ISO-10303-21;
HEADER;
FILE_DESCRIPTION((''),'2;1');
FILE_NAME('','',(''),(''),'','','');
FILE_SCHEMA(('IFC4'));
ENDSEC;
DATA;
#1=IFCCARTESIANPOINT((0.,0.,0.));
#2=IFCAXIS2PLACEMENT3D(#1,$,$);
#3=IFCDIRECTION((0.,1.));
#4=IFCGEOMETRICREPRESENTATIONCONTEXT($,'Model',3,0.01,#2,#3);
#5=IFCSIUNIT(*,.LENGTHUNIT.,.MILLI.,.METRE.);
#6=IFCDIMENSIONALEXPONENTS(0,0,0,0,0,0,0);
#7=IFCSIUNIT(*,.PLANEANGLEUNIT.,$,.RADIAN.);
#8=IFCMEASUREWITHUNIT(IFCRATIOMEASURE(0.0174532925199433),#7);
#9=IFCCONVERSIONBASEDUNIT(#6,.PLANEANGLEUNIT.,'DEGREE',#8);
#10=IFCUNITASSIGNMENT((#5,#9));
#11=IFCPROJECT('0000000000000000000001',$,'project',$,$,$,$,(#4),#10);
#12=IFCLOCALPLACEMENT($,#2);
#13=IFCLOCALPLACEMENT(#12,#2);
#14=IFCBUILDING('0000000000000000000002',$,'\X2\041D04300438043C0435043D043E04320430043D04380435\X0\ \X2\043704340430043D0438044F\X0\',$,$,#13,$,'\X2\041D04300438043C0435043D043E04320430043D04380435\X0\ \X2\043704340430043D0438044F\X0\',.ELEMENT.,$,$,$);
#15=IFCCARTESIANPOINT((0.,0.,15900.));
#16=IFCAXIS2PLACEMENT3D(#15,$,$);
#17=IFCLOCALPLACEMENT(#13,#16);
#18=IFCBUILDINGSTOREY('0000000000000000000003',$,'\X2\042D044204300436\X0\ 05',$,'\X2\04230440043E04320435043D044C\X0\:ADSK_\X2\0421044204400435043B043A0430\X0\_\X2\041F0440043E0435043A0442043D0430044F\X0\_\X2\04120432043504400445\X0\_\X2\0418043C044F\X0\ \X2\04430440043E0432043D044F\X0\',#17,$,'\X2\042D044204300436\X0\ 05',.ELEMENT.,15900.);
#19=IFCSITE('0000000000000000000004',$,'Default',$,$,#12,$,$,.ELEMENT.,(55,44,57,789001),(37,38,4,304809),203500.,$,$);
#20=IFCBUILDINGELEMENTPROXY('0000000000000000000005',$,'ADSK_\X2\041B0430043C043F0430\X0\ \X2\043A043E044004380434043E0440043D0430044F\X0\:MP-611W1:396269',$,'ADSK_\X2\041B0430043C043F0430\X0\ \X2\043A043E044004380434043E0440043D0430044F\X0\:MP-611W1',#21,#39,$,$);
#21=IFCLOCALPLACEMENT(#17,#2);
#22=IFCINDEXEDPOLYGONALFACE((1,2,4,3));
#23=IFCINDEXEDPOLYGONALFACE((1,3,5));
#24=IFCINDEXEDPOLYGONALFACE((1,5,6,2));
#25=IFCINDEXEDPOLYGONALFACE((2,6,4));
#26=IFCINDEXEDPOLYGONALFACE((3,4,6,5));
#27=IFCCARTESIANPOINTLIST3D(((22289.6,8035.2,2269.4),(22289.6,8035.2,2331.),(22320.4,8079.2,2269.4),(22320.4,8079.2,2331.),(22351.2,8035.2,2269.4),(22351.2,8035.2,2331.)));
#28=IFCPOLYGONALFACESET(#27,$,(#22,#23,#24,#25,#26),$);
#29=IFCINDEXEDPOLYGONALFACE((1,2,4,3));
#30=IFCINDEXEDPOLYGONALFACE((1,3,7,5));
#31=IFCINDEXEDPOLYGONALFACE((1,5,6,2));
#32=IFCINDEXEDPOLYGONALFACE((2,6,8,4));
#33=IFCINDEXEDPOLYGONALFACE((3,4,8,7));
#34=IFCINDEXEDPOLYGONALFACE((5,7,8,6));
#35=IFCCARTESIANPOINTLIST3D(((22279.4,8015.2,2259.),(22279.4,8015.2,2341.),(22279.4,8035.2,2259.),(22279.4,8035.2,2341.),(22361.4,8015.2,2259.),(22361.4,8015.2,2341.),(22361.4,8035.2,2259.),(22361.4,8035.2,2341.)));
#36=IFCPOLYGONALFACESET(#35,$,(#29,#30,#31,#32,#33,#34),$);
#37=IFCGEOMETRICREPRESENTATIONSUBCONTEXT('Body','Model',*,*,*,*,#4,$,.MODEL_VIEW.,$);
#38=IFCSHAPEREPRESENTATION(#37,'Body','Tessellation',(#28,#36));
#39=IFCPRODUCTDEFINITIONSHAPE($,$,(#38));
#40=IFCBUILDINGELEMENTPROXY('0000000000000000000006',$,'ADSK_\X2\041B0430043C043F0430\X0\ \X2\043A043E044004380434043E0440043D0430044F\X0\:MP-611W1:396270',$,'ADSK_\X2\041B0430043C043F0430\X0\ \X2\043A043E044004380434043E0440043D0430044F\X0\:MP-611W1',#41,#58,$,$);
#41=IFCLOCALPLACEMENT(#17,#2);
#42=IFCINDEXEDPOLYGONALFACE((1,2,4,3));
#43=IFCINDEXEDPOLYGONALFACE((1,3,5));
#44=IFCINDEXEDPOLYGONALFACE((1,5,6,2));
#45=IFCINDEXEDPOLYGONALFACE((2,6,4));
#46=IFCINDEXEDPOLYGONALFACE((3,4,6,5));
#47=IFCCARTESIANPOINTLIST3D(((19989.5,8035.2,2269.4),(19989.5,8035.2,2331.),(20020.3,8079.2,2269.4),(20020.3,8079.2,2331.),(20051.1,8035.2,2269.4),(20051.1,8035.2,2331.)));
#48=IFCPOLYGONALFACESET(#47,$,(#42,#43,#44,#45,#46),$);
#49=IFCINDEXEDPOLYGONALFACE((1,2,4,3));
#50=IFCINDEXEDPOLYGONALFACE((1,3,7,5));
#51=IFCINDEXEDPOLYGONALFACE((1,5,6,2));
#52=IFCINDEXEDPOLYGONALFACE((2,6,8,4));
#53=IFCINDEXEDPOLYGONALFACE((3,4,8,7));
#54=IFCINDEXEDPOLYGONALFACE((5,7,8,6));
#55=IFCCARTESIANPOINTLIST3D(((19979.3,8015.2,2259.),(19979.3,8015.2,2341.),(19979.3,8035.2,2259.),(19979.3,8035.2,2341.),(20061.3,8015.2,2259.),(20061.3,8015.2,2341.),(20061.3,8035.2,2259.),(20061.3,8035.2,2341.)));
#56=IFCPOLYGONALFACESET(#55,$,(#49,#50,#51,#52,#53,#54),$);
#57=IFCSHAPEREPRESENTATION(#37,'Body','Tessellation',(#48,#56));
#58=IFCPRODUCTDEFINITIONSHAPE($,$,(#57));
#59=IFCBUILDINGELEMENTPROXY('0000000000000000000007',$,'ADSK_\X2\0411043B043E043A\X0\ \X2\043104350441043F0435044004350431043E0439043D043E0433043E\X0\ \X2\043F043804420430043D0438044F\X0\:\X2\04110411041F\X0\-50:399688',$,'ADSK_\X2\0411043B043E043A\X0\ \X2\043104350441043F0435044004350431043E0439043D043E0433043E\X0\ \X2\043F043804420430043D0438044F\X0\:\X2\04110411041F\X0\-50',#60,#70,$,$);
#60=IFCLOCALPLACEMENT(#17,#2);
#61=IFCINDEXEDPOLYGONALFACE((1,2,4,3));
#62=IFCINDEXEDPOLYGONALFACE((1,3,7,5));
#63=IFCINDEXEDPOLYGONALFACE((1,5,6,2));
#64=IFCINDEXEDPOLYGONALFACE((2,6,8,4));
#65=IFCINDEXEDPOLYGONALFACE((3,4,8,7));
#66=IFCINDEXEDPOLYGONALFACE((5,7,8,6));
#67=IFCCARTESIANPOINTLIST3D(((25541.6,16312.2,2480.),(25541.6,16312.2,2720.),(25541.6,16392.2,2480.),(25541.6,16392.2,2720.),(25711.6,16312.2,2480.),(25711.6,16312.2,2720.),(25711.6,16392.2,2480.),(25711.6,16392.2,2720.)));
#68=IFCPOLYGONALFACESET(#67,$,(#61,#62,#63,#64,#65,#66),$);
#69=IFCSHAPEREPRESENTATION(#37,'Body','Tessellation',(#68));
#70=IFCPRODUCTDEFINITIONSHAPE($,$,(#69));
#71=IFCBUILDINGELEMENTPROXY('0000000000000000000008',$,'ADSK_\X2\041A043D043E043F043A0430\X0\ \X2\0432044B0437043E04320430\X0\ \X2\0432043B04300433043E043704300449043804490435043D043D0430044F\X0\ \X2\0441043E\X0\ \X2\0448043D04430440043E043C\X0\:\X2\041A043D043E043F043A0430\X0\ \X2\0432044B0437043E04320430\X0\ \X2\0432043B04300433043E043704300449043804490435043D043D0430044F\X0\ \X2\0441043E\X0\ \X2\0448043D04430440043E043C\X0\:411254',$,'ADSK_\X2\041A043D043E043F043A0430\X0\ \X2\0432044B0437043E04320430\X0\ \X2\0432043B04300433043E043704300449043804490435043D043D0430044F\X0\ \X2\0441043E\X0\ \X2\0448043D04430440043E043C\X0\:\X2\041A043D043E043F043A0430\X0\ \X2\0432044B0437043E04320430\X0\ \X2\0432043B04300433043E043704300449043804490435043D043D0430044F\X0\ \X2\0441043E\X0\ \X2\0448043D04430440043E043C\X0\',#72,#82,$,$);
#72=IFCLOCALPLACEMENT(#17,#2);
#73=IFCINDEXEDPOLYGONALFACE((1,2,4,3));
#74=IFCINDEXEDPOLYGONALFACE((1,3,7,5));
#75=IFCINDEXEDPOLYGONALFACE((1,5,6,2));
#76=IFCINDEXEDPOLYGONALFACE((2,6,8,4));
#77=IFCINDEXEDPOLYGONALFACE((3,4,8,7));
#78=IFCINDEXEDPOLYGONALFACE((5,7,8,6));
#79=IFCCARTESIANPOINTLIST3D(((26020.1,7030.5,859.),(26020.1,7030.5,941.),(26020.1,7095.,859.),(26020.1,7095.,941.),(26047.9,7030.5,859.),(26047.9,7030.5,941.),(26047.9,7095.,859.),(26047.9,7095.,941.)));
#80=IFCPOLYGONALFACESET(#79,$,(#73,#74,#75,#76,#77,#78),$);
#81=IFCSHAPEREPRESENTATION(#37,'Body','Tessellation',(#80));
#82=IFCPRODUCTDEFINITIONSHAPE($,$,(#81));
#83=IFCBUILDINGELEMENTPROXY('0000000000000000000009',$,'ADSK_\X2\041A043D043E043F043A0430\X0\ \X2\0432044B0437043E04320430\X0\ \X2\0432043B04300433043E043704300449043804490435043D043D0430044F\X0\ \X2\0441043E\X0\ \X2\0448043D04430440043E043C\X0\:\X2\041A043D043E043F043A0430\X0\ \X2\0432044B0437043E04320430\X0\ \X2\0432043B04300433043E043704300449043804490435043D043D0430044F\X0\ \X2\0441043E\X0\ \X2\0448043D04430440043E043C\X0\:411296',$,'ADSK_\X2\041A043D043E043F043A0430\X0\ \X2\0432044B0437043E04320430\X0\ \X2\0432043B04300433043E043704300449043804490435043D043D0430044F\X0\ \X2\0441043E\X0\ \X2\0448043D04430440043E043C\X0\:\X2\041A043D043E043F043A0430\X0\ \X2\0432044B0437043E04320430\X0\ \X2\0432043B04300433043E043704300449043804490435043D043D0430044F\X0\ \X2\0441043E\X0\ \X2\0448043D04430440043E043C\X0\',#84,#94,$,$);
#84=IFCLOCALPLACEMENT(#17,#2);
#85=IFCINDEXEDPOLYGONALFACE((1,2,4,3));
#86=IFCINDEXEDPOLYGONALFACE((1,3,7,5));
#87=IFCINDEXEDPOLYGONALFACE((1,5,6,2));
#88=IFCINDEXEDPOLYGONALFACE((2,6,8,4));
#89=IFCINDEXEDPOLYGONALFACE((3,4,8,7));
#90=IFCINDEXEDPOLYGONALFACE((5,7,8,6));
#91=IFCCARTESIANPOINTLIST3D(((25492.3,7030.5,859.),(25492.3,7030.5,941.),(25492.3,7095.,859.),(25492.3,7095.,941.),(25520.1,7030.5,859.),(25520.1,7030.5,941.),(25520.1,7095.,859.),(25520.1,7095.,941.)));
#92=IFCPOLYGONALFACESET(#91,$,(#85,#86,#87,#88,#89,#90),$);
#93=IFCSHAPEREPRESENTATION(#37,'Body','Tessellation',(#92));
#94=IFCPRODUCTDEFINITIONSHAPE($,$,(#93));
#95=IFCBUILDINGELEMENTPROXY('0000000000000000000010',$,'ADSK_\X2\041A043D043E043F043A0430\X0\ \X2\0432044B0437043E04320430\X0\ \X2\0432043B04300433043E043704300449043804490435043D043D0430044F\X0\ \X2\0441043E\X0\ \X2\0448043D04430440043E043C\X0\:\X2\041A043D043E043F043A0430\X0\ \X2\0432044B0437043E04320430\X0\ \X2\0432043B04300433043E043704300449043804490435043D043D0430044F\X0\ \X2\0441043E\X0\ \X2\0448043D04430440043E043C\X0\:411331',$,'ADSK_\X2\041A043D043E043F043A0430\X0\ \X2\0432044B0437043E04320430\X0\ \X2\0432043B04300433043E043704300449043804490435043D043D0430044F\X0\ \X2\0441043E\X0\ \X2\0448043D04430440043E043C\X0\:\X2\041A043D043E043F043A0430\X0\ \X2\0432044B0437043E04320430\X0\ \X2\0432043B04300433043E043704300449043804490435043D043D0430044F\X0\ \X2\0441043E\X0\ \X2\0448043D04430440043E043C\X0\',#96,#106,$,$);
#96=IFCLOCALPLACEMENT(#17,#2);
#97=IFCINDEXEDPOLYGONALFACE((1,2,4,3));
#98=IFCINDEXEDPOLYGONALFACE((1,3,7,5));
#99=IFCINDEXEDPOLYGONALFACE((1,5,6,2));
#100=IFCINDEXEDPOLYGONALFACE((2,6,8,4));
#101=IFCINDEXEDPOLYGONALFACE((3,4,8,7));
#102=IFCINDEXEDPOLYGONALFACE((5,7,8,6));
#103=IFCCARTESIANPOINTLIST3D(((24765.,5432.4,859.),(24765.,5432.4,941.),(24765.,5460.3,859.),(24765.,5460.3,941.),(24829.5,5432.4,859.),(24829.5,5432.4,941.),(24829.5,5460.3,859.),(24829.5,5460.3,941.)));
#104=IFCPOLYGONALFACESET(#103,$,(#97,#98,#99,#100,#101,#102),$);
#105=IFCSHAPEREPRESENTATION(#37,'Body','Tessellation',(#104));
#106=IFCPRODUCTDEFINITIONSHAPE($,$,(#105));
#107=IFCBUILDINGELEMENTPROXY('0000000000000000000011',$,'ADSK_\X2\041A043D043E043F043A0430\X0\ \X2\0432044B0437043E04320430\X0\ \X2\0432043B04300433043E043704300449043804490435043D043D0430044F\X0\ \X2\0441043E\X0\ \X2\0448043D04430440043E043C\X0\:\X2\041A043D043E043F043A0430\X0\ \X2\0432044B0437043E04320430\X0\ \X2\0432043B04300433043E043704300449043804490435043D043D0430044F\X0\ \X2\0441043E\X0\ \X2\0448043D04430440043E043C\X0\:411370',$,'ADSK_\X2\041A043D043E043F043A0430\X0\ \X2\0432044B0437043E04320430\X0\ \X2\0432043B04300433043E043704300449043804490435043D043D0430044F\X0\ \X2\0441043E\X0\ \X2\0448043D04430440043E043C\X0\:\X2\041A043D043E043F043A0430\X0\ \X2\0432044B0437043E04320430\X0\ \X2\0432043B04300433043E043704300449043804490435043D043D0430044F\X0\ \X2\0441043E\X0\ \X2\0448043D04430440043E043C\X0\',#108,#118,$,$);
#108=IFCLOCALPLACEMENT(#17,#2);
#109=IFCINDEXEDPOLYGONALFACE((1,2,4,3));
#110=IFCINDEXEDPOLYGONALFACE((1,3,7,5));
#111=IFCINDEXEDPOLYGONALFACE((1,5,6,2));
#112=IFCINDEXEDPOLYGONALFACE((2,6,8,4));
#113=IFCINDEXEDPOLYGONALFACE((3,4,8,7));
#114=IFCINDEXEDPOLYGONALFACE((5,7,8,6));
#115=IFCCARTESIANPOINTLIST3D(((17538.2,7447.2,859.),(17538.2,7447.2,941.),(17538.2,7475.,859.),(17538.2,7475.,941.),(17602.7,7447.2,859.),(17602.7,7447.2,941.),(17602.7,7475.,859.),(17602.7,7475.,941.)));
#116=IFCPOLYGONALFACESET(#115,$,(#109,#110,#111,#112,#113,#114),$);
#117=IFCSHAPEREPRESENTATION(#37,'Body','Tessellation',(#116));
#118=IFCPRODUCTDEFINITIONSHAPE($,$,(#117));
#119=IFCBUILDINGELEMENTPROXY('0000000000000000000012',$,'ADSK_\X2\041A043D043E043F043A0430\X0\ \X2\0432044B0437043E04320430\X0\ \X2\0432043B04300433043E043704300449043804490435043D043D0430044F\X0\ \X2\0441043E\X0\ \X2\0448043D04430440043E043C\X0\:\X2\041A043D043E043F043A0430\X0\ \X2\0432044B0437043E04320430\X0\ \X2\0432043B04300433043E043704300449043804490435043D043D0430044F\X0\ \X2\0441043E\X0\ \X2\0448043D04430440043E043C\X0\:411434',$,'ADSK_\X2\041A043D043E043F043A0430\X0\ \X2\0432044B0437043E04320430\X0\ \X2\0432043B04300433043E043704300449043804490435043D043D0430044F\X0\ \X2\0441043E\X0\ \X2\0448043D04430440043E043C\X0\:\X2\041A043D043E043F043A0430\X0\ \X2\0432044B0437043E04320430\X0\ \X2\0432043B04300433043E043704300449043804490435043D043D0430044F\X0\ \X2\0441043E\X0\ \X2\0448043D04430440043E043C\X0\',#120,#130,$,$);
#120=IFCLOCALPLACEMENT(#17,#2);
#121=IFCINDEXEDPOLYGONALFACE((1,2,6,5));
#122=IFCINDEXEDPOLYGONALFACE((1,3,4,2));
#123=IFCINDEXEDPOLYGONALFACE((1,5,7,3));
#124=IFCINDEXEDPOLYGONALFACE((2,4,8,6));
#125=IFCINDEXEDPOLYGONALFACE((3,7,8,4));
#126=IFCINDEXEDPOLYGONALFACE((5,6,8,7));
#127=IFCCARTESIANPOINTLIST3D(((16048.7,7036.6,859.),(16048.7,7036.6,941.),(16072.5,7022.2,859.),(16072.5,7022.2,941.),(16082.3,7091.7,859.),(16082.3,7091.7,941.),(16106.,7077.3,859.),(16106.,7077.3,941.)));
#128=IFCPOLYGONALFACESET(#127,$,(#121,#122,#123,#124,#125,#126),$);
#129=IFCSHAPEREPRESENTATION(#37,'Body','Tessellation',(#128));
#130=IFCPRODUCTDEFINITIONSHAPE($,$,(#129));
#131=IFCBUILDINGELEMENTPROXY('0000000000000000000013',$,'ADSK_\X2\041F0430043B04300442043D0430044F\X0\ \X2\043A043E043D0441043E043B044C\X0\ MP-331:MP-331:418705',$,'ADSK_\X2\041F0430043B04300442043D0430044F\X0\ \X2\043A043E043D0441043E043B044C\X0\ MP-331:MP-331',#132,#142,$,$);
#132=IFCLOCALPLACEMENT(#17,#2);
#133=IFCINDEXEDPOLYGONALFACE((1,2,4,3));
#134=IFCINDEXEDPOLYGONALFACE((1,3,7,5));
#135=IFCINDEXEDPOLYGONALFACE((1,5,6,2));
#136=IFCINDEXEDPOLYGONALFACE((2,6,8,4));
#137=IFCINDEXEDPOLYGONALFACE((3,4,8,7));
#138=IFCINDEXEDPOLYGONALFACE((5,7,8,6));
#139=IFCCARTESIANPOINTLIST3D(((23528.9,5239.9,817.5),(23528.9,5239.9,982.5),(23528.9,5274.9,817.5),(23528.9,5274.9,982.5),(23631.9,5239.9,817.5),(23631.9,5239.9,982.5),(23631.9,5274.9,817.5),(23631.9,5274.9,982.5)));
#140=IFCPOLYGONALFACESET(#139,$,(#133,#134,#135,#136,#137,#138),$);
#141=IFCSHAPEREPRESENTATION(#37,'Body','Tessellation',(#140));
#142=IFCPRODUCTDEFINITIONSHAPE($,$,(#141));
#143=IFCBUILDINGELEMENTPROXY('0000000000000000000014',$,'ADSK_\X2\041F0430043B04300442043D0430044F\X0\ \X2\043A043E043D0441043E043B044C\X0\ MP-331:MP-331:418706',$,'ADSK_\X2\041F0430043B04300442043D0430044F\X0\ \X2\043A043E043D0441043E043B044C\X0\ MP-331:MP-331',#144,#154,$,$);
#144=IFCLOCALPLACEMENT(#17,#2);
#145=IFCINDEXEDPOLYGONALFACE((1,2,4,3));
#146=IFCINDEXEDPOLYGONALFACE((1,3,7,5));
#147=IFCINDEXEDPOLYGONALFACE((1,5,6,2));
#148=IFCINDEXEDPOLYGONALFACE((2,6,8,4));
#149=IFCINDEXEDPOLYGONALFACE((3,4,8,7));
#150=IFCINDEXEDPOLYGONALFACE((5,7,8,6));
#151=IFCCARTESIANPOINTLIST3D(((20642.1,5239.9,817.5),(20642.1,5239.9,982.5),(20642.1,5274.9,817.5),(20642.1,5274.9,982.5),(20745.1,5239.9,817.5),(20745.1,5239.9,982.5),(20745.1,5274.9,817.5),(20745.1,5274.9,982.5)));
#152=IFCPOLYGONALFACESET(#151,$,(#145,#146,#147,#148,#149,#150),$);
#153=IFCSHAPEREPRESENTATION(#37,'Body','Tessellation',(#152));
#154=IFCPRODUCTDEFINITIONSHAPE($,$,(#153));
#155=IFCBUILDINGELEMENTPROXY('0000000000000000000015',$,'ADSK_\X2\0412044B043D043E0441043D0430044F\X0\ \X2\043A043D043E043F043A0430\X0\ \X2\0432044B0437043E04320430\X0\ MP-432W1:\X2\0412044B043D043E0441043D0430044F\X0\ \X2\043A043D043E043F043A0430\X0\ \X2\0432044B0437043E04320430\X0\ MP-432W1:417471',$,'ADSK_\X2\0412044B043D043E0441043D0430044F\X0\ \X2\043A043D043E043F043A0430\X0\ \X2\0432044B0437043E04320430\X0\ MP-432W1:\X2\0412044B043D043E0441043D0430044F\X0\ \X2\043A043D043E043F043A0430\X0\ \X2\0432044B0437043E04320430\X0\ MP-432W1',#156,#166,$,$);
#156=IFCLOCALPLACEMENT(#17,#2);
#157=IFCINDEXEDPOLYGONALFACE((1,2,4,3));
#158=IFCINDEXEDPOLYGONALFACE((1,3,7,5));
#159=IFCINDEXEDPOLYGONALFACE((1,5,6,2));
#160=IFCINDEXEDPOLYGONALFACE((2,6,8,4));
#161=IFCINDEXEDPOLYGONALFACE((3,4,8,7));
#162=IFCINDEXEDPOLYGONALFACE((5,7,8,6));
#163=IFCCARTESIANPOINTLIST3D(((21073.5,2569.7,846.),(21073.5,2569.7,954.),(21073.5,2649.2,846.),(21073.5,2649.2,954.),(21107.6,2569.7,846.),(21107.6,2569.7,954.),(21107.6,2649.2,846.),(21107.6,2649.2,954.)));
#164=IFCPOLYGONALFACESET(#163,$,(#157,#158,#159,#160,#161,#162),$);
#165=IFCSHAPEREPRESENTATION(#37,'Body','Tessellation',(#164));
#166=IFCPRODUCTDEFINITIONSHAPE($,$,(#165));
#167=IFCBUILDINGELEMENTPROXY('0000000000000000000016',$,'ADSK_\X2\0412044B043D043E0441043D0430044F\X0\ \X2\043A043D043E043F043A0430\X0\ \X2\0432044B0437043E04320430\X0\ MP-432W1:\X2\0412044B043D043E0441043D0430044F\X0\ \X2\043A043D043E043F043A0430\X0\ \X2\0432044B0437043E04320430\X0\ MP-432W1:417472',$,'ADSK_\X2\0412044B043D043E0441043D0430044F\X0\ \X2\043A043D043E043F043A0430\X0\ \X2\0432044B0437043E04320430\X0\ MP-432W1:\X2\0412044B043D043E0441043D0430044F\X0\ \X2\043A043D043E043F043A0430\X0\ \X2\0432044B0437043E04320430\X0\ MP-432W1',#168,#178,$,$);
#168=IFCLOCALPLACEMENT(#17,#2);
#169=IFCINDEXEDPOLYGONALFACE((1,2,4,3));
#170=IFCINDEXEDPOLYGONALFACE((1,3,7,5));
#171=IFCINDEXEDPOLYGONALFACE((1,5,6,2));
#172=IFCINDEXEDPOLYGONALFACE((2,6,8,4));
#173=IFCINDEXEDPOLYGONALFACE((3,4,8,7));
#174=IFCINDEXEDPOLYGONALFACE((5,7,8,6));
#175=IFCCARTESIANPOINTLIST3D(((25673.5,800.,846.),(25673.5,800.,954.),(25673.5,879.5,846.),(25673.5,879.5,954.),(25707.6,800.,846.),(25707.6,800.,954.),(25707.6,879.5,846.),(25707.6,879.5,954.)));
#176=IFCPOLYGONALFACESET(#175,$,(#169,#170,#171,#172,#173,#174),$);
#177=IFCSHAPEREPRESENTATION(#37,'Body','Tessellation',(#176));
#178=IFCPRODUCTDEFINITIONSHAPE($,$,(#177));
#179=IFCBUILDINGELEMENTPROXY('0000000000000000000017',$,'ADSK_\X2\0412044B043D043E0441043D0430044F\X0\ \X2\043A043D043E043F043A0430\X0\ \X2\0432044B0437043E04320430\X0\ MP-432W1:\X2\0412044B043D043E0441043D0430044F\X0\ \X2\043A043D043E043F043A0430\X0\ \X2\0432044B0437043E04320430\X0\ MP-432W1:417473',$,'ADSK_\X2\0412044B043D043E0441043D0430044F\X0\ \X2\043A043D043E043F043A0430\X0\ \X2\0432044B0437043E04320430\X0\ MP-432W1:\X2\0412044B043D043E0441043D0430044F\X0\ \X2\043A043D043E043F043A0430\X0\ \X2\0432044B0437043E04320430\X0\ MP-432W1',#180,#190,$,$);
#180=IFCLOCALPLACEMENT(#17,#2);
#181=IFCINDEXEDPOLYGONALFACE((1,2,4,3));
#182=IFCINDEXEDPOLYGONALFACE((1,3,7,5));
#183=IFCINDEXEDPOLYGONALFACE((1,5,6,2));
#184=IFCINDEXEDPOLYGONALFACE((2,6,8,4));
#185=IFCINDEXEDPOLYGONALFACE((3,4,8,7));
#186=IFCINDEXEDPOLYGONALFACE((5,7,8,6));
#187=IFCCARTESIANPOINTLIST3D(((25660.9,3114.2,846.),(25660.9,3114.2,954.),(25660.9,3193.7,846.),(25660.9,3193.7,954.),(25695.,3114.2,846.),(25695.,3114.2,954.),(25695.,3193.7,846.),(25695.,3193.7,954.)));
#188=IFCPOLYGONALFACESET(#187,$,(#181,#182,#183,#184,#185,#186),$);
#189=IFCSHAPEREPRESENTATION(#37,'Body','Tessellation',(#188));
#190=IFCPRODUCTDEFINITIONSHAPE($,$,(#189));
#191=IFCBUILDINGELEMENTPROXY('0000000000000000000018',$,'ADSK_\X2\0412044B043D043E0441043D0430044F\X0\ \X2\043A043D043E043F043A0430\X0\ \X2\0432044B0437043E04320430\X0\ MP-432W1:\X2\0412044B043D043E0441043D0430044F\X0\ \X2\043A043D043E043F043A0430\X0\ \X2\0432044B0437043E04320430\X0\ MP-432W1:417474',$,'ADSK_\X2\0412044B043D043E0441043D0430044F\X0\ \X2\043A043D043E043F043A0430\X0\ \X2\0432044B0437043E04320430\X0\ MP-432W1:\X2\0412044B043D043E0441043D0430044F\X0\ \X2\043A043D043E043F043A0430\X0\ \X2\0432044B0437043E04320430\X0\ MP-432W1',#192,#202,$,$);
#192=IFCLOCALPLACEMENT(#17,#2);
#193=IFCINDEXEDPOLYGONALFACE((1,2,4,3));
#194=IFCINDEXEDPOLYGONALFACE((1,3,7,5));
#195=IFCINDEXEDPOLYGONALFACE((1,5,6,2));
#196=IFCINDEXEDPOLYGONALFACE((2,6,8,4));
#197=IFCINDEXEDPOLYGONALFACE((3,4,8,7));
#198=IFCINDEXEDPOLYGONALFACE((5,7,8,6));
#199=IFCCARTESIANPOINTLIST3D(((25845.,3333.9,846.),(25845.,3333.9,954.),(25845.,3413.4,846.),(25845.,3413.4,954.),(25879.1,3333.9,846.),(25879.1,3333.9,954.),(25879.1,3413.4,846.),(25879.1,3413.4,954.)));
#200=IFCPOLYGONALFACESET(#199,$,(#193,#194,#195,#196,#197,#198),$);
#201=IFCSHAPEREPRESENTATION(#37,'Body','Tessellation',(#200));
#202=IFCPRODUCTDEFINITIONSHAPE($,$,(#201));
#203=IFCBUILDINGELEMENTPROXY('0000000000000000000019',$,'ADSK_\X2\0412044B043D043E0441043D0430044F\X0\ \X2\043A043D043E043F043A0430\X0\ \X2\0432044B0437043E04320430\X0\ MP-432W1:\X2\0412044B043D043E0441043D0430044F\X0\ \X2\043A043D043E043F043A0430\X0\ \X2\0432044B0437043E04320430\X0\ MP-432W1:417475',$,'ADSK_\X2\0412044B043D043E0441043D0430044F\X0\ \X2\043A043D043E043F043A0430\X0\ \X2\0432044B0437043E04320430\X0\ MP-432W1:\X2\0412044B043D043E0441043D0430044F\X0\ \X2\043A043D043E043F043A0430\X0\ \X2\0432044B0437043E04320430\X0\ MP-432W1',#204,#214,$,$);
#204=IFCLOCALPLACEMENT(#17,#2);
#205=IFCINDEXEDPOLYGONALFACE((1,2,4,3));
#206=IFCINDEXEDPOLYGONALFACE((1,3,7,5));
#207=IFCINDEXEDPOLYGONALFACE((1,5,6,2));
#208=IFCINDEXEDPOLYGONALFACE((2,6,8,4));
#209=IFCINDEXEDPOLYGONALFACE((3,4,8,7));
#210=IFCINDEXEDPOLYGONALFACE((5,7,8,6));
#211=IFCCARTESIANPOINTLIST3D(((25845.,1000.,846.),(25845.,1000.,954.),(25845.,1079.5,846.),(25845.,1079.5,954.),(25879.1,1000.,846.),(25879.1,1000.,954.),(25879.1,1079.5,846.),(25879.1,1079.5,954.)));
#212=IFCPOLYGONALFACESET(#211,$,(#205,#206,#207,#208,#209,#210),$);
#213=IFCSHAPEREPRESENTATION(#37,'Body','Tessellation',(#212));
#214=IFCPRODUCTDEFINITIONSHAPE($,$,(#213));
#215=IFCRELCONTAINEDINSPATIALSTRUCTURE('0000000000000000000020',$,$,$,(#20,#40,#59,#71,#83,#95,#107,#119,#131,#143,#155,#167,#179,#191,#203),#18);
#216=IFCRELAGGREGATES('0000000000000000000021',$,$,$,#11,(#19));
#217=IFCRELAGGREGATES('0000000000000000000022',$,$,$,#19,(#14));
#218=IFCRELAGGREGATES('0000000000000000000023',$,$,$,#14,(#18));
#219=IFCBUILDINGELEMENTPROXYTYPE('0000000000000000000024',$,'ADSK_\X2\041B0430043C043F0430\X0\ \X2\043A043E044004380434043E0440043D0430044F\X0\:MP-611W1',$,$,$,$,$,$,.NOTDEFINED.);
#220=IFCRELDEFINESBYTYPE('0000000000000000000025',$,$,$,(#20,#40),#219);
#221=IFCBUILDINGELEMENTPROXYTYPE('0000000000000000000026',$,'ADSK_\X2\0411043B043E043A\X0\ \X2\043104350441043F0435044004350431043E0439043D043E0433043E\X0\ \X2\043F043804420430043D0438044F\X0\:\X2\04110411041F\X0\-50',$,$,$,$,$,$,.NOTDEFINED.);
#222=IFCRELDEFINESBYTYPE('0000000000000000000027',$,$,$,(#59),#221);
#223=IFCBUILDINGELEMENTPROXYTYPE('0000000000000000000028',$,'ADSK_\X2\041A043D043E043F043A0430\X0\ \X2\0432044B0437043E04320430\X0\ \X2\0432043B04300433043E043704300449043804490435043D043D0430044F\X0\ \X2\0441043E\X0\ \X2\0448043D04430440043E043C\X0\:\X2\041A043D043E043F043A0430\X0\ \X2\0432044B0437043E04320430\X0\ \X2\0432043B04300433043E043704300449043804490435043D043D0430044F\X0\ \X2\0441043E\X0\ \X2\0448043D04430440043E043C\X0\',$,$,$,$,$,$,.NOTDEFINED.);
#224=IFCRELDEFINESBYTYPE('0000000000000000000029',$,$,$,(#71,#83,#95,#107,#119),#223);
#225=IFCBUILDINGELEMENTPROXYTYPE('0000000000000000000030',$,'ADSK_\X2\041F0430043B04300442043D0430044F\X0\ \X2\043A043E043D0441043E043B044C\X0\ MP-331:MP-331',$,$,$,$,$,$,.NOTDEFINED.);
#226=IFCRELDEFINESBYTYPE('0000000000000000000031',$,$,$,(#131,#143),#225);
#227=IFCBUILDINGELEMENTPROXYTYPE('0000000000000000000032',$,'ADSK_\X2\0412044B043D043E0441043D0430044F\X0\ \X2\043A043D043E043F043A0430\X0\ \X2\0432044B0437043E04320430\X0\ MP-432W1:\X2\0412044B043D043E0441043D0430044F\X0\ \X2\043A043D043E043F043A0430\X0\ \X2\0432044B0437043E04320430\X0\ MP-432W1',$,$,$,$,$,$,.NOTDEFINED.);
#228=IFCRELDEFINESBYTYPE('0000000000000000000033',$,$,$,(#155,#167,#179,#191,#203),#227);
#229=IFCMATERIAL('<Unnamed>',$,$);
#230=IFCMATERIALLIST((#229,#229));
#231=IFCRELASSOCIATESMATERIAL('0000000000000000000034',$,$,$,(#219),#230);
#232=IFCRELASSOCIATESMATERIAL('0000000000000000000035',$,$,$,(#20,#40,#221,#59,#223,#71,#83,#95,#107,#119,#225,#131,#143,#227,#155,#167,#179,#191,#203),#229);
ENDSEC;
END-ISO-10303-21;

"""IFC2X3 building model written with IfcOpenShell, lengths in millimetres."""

from ifc_helpers import new_model, entity, si_unit, converted_unit, direction, frame, origin, origin_2d_with_axis, place, context, subcontext, project, spatial, polyline, rectangle, outline, extrude, source, transform, mapped, material, material_list, type_object, type_shapes, element, save


model = new_model("IFC2X3")

# Units and contexts
model_context = context("Model", 3, precision=0.01, world=origin(), true_north=direction((0.0, 1.0)))
body_context = subcontext(model_context, "Body", "Model", "MODEL_VIEW")
ifc_project = project(units=[si_unit("LENGTHUNIT", "METRE", prefix="MILLI"), converted_unit("PLANEANGLEUNIT", "DEGREE", entity("IfcRatioMeasure", 0.0174532925199433), si_unit("PLANEANGLEUNIT", "RADIAN"), dimensions=[0, 0, 0, 0, 0, 0, 0])], contexts=[model_context])

# Site, building, storey
site_placement = place(None, origin())
site = spatial("IfcSite", under=ifc_project, at=site_placement, Name="Default", CompositionType="ELEMENT", RefLatitude=(55, 44, 57, 789001), RefLongitude=(37, 38, 4, 304809), RefElevation=203500.0)
building_placement = place(site_placement, origin())
building = spatial("IfcBuilding", under=site, at=building_placement, Name="Наименование здания", LongName="Наименование здания", CompositionType="ELEMENT")
storey_placement = place(building_placement, frame((0.0, 0.0, 15900.0)))
storey = spatial("IfcBuildingStorey", under=building, at=storey_placement, Name="Этаж 05", ObjectType="Уровень:ADSK_Стрелка_Проектная_Вверх_Имя уровня", LongName="Этаж 05", CompositionType="ELEMENT", Elevation=15900.0)

# Building element proxies
ifc_material_1 = material(Name="<Unnamed>")
ifc_material_list_1 = material_list([ifc_material_1, ifc_material_1])
building_element_proxy_type_1 = type_object("IfcBuildingElementProxyType", Name="ADSK_Лампа коридорная:MP-611W1", PredefinedType="NOTDEFINED", material=ifc_material_list_1)
shared_shape_1 = source(origin(), body_context, "Body", "SweptSolid", [
    extrude(outline(polyline([(-30.8, -14.7), (30.8, -14.7), (0.0, 29.3), (-30.8, -14.7)])), frame((0.0, -2.7, -30.6), z_axis=(0.0, 0.0, 1.0), x_axis=(-1.0, 0.0, 0.0)), (0.0, 0.0, 1.0), 61.6),
    extrude(rectangle(XDim=82.0, YDim=20.0, at=origin_2d_with_axis()), frame((0.0, 22.0, -41.0), z_axis=(0.0, 0.0, 1.0), x_axis=(-1.0, 0.0, 0.0)), (0.0, 0.0, 1.0), 82.0),
])
type_shapes(building_element_proxy_type_1, [shared_shape_1])
for number, where, z_axis, x_axis, name in (
    (1, (22320.4, 8047.1, 2300.0), (0.0, 0.0, 1.0), (-1.0, 0.0, 0.0), "ADSK_Лампа коридорная:MP-611W1:396269"),
    (2, (20020.3, 8047.1, 2300.0), (0.0, 0.0, 1.0), (-1.0, 0.0, 0.0), "ADSK_Лампа коридорная:MP-611W1:396270"),
):
    element("IfcBuildingElementProxy", number, at=place(storey_placement, frame(where, z_axis=z_axis, x_axis=x_axis)), inside=storey, type_object=building_element_proxy_type_1, material=ifc_material_1, Name=name, ObjectType="ADSK_Лампа коридорная:MP-611W1", context=body_context, shape_type="MappedRepresentation", body=[
        mapped(shared_shape_1, transform((0.0, 0.0, 0.0), scale=1.0)),
    ])
building_element_proxy_type_2 = type_object("IfcBuildingElementProxyType", Name="ADSK_Блок бесперебойного питания:ББП-50", PredefinedType="NOTDEFINED", material=ifc_material_1)
shared_shape_2 = source(origin(), body_context, "Body", "SweptSolid", [
    extrude(rectangle(XDim=170.0, YDim=80.0, at=origin_2d_with_axis()), frame((0.0, -8.0, -120.0), z_axis=(0.0, 0.0, 1.0), x_axis=(-1.0, 0.0, 0.0)), (0.0, 0.0, 1.0), 240.0),
])
type_shapes(building_element_proxy_type_2, [shared_shape_2])
proxy_1_placement = place(storey_placement, frame((25626.6, 16360.2, 2600.0)))
element("IfcBuildingElementProxy", 3, at=proxy_1_placement, inside=storey, type_object=building_element_proxy_type_2, material=ifc_material_1, Name="ADSK_Блок бесперебойного питания:ББП-50:399688", ObjectType="ADSK_Блок бесперебойного питания:ББП-50", context=body_context, shape_type="MappedRepresentation", body=[
    mapped(shared_shape_2, transform((0.0, 0.0, 0.0), scale=1.0)),
])
building_element_proxy_type_3 = type_object("IfcBuildingElementProxyType", Name="ADSK_Кнопка вызова влагозащищенная со шнуром:Кнопка вызова влагозащищенная со шнуром", PredefinedType="NOTDEFINED", material=ifc_material_1)
shared_shape_3 = source(origin(), body_context, "Body", "SweptSolid", [
    extrude(rectangle(XDim=64.5, YDim=27.8, at=origin_2d_with_axis()), frame((32.2, 13.9, 0.0), z_axis=(0.0, 0.0, 1.0), x_axis=(-1.0, 0.0, 0.0)), (0.0, 0.0, 1.0), 82.0),
])
type_shapes(building_element_proxy_type_3, [shared_shape_3])
for number, where, z_axis, x_axis, name in (
    (4, (26047.9, 7030.5, 859.0), (0.0, 0.0, 1.0), (0.0, 1.0, 0.0), "ADSK_Кнопка вызова влагозащищенная со шнуром:Кнопка вызова влагозащищенная со шнуром:411254"),
    (5, (25492.3, 7095.0, 859.0), (0.0, 0.0, 1.0), (0.0, -1.0, 0.0), "ADSK_Кнопка вызова влагозащищенная со шнуром:Кнопка вызова влагозащищенная со шнуром:411296"),
    (6, (24829.5, 5460.3, 859.0), (0.0, 0.0, 1.0), (-1.0, 0.0, 0.0), "ADSK_Кнопка вызова влагозащищенная со шнуром:Кнопка вызова влагозащищенная со шнуром:411331"),
):
    element("IfcBuildingElementProxy", number, at=place(storey_placement, frame(where, z_axis=z_axis, x_axis=x_axis)), inside=storey, type_object=building_element_proxy_type_3, material=ifc_material_1, Name=name, ObjectType="ADSK_Кнопка вызова влагозащищенная со шнуром:Кнопка вызова влагозащищенная со шнуром", context=body_context, shape_type="MappedRepresentation", body=[
        mapped(shared_shape_3, transform((0.0, 0.0, 0.0), scale=1.0)),
    ])
proxy_2_placement = place(storey_placement, frame((17538.2, 7447.2, 859.0)))
element("IfcBuildingElementProxy", 7, at=proxy_2_placement, inside=storey, type_object=building_element_proxy_type_3, material=ifc_material_1, Name="ADSK_Кнопка вызова влагозащищенная со шнуром:Кнопка вызова влагозащищенная со шнуром:411370", ObjectType="ADSK_Кнопка вызова влагозащищенная со шнуром:Кнопка вызова влагозащищенная со шнуром", context=body_context, shape_type="MappedRepresentation", body=[
    mapped(shared_shape_3, transform((0.0, 0.0, 0.0), scale=1.0)),
])
proxy_3_placement = place(storey_placement, frame((16072.5, 7022.2, 859.0), z_axis=(0.0, 0.0, 1.0), x_axis=(0.519535, 0.854449, 0.0)))
element("IfcBuildingElementProxy", 8, at=proxy_3_placement, inside=storey, type_object=building_element_proxy_type_3, material=ifc_material_1, Name="ADSK_Кнопка вызова влагозащищенная со шнуром:Кнопка вызова влагозащищенная со шнуром:411434", ObjectType="ADSK_Кнопка вызова влагозащищенная со шнуром:Кнопка вызова влагозащищенная со шнуром", context=body_context, shape_type="MappedRepresentation", body=[
    mapped(shared_shape_3, transform((0.0, 0.0, 0.0), scale=1.0)),
])
building_element_proxy_type_4 = type_object("IfcBuildingElementProxyType", Name="ADSK_Палатная консоль MP-331:MP-331", PredefinedType="NOTDEFINED", material=ifc_material_1)
shared_shape_4 = source(origin(), body_context, "Body", "SweptSolid", [
    extrude(rectangle(XDim=103.0, YDim=35.0, at=origin_2d_with_axis()), frame((0.0, 14.5, -82.5), z_axis=(0.0, 0.0, 1.0), x_axis=(-1.0, 0.0, 0.0)), (0.0, 0.0, 1.0), 165.0),
])
type_shapes(building_element_proxy_type_4, [shared_shape_4])
for number, where, name in (
    (9, (23580.4, 5242.9, 900.0), "ADSK_Палатная консоль MP-331:MP-331:418705"),
    (10, (20693.6, 5242.9, 900.0), "ADSK_Палатная консоль MP-331:MP-331:418706"),
):
    element("IfcBuildingElementProxy", number, at=place(storey_placement, frame(where)), inside=storey, type_object=building_element_proxy_type_4, material=ifc_material_1, Name=name, ObjectType="ADSK_Палатная консоль MP-331:MP-331", context=body_context, shape_type="MappedRepresentation", body=[
        mapped(shared_shape_4, transform((0.0, 0.0, 0.0), scale=1.0)),
    ])
building_element_proxy_type_5 = type_object("IfcBuildingElementProxyType", Name="ADSK_Выносная кнопка вызова MP-432W1:Выносная кнопка вызова MP-432W1", PredefinedType="NOTDEFINED", material=ifc_material_1)
shared_shape_5 = source(origin(), body_context, "Body", "SweptSolid", [
    extrude(rectangle(XDim=79.5, YDim=34.1, at=origin_2d_with_axis()), frame((0.0, 15.0, -54.0), z_axis=(0.0, 0.0, 1.0), x_axis=(-1.0, 0.0, 0.0)), (0.0, 0.0, 1.0), 108.0),
])
type_shapes(building_element_proxy_type_5, [shared_shape_5])
for number, where, z_axis, x_axis, name in (
    (11, (21075.6, 2609.4, 900.0), (0.0, 0.0, 1.0), (0.0, -1.0, 0.0), "ADSK_Выносная кнопка вызова MP-432W1:Выносная кнопка вызова MP-432W1:417471"),
    (12, (25675.6, 839.8, 900.0), (0.0, 0.0, 1.0), (0.0, -1.0, 0.0), "ADSK_Выносная кнопка вызова MP-432W1:Выносная кнопка вызова MP-432W1:417472"),
    (13, (25663.0, 3153.9, 900.0), (0.0, 0.0, 1.0), (0.0, -1.0, 0.0), "ADSK_Выносная кнопка вызова MP-432W1:Выносная кнопка вызова MP-432W1:417473"),
    (14, (25877.0, 3373.7, 900.0), (0.0, 0.0, 1.0), (0.0, 1.0, 0.0), "ADSK_Выносная кнопка вызова MP-432W1:Выносная кнопка вызова MP-432W1:417474"),
    (15, (25877.0, 1039.8, 900.0), (0.0, 0.0, 1.0), (0.0, 1.0, 0.0), "ADSK_Выносная кнопка вызова MP-432W1:Выносная кнопка вызова MP-432W1:417475"),
):
    element("IfcBuildingElementProxy", number, at=place(storey_placement, frame(where, z_axis=z_axis, x_axis=x_axis)), inside=storey, type_object=building_element_proxy_type_5, material=ifc_material_1, Name=name, ObjectType="ADSK_Выносная кнопка вызова MP-432W1:Выносная кнопка вызова MP-432W1", context=body_context, shape_type="MappedRepresentation", body=[
        mapped(shared_shape_5, transform((0.0, 0.0, 0.0), scale=1.0)),
    ])

save(model, "model.ifc")
